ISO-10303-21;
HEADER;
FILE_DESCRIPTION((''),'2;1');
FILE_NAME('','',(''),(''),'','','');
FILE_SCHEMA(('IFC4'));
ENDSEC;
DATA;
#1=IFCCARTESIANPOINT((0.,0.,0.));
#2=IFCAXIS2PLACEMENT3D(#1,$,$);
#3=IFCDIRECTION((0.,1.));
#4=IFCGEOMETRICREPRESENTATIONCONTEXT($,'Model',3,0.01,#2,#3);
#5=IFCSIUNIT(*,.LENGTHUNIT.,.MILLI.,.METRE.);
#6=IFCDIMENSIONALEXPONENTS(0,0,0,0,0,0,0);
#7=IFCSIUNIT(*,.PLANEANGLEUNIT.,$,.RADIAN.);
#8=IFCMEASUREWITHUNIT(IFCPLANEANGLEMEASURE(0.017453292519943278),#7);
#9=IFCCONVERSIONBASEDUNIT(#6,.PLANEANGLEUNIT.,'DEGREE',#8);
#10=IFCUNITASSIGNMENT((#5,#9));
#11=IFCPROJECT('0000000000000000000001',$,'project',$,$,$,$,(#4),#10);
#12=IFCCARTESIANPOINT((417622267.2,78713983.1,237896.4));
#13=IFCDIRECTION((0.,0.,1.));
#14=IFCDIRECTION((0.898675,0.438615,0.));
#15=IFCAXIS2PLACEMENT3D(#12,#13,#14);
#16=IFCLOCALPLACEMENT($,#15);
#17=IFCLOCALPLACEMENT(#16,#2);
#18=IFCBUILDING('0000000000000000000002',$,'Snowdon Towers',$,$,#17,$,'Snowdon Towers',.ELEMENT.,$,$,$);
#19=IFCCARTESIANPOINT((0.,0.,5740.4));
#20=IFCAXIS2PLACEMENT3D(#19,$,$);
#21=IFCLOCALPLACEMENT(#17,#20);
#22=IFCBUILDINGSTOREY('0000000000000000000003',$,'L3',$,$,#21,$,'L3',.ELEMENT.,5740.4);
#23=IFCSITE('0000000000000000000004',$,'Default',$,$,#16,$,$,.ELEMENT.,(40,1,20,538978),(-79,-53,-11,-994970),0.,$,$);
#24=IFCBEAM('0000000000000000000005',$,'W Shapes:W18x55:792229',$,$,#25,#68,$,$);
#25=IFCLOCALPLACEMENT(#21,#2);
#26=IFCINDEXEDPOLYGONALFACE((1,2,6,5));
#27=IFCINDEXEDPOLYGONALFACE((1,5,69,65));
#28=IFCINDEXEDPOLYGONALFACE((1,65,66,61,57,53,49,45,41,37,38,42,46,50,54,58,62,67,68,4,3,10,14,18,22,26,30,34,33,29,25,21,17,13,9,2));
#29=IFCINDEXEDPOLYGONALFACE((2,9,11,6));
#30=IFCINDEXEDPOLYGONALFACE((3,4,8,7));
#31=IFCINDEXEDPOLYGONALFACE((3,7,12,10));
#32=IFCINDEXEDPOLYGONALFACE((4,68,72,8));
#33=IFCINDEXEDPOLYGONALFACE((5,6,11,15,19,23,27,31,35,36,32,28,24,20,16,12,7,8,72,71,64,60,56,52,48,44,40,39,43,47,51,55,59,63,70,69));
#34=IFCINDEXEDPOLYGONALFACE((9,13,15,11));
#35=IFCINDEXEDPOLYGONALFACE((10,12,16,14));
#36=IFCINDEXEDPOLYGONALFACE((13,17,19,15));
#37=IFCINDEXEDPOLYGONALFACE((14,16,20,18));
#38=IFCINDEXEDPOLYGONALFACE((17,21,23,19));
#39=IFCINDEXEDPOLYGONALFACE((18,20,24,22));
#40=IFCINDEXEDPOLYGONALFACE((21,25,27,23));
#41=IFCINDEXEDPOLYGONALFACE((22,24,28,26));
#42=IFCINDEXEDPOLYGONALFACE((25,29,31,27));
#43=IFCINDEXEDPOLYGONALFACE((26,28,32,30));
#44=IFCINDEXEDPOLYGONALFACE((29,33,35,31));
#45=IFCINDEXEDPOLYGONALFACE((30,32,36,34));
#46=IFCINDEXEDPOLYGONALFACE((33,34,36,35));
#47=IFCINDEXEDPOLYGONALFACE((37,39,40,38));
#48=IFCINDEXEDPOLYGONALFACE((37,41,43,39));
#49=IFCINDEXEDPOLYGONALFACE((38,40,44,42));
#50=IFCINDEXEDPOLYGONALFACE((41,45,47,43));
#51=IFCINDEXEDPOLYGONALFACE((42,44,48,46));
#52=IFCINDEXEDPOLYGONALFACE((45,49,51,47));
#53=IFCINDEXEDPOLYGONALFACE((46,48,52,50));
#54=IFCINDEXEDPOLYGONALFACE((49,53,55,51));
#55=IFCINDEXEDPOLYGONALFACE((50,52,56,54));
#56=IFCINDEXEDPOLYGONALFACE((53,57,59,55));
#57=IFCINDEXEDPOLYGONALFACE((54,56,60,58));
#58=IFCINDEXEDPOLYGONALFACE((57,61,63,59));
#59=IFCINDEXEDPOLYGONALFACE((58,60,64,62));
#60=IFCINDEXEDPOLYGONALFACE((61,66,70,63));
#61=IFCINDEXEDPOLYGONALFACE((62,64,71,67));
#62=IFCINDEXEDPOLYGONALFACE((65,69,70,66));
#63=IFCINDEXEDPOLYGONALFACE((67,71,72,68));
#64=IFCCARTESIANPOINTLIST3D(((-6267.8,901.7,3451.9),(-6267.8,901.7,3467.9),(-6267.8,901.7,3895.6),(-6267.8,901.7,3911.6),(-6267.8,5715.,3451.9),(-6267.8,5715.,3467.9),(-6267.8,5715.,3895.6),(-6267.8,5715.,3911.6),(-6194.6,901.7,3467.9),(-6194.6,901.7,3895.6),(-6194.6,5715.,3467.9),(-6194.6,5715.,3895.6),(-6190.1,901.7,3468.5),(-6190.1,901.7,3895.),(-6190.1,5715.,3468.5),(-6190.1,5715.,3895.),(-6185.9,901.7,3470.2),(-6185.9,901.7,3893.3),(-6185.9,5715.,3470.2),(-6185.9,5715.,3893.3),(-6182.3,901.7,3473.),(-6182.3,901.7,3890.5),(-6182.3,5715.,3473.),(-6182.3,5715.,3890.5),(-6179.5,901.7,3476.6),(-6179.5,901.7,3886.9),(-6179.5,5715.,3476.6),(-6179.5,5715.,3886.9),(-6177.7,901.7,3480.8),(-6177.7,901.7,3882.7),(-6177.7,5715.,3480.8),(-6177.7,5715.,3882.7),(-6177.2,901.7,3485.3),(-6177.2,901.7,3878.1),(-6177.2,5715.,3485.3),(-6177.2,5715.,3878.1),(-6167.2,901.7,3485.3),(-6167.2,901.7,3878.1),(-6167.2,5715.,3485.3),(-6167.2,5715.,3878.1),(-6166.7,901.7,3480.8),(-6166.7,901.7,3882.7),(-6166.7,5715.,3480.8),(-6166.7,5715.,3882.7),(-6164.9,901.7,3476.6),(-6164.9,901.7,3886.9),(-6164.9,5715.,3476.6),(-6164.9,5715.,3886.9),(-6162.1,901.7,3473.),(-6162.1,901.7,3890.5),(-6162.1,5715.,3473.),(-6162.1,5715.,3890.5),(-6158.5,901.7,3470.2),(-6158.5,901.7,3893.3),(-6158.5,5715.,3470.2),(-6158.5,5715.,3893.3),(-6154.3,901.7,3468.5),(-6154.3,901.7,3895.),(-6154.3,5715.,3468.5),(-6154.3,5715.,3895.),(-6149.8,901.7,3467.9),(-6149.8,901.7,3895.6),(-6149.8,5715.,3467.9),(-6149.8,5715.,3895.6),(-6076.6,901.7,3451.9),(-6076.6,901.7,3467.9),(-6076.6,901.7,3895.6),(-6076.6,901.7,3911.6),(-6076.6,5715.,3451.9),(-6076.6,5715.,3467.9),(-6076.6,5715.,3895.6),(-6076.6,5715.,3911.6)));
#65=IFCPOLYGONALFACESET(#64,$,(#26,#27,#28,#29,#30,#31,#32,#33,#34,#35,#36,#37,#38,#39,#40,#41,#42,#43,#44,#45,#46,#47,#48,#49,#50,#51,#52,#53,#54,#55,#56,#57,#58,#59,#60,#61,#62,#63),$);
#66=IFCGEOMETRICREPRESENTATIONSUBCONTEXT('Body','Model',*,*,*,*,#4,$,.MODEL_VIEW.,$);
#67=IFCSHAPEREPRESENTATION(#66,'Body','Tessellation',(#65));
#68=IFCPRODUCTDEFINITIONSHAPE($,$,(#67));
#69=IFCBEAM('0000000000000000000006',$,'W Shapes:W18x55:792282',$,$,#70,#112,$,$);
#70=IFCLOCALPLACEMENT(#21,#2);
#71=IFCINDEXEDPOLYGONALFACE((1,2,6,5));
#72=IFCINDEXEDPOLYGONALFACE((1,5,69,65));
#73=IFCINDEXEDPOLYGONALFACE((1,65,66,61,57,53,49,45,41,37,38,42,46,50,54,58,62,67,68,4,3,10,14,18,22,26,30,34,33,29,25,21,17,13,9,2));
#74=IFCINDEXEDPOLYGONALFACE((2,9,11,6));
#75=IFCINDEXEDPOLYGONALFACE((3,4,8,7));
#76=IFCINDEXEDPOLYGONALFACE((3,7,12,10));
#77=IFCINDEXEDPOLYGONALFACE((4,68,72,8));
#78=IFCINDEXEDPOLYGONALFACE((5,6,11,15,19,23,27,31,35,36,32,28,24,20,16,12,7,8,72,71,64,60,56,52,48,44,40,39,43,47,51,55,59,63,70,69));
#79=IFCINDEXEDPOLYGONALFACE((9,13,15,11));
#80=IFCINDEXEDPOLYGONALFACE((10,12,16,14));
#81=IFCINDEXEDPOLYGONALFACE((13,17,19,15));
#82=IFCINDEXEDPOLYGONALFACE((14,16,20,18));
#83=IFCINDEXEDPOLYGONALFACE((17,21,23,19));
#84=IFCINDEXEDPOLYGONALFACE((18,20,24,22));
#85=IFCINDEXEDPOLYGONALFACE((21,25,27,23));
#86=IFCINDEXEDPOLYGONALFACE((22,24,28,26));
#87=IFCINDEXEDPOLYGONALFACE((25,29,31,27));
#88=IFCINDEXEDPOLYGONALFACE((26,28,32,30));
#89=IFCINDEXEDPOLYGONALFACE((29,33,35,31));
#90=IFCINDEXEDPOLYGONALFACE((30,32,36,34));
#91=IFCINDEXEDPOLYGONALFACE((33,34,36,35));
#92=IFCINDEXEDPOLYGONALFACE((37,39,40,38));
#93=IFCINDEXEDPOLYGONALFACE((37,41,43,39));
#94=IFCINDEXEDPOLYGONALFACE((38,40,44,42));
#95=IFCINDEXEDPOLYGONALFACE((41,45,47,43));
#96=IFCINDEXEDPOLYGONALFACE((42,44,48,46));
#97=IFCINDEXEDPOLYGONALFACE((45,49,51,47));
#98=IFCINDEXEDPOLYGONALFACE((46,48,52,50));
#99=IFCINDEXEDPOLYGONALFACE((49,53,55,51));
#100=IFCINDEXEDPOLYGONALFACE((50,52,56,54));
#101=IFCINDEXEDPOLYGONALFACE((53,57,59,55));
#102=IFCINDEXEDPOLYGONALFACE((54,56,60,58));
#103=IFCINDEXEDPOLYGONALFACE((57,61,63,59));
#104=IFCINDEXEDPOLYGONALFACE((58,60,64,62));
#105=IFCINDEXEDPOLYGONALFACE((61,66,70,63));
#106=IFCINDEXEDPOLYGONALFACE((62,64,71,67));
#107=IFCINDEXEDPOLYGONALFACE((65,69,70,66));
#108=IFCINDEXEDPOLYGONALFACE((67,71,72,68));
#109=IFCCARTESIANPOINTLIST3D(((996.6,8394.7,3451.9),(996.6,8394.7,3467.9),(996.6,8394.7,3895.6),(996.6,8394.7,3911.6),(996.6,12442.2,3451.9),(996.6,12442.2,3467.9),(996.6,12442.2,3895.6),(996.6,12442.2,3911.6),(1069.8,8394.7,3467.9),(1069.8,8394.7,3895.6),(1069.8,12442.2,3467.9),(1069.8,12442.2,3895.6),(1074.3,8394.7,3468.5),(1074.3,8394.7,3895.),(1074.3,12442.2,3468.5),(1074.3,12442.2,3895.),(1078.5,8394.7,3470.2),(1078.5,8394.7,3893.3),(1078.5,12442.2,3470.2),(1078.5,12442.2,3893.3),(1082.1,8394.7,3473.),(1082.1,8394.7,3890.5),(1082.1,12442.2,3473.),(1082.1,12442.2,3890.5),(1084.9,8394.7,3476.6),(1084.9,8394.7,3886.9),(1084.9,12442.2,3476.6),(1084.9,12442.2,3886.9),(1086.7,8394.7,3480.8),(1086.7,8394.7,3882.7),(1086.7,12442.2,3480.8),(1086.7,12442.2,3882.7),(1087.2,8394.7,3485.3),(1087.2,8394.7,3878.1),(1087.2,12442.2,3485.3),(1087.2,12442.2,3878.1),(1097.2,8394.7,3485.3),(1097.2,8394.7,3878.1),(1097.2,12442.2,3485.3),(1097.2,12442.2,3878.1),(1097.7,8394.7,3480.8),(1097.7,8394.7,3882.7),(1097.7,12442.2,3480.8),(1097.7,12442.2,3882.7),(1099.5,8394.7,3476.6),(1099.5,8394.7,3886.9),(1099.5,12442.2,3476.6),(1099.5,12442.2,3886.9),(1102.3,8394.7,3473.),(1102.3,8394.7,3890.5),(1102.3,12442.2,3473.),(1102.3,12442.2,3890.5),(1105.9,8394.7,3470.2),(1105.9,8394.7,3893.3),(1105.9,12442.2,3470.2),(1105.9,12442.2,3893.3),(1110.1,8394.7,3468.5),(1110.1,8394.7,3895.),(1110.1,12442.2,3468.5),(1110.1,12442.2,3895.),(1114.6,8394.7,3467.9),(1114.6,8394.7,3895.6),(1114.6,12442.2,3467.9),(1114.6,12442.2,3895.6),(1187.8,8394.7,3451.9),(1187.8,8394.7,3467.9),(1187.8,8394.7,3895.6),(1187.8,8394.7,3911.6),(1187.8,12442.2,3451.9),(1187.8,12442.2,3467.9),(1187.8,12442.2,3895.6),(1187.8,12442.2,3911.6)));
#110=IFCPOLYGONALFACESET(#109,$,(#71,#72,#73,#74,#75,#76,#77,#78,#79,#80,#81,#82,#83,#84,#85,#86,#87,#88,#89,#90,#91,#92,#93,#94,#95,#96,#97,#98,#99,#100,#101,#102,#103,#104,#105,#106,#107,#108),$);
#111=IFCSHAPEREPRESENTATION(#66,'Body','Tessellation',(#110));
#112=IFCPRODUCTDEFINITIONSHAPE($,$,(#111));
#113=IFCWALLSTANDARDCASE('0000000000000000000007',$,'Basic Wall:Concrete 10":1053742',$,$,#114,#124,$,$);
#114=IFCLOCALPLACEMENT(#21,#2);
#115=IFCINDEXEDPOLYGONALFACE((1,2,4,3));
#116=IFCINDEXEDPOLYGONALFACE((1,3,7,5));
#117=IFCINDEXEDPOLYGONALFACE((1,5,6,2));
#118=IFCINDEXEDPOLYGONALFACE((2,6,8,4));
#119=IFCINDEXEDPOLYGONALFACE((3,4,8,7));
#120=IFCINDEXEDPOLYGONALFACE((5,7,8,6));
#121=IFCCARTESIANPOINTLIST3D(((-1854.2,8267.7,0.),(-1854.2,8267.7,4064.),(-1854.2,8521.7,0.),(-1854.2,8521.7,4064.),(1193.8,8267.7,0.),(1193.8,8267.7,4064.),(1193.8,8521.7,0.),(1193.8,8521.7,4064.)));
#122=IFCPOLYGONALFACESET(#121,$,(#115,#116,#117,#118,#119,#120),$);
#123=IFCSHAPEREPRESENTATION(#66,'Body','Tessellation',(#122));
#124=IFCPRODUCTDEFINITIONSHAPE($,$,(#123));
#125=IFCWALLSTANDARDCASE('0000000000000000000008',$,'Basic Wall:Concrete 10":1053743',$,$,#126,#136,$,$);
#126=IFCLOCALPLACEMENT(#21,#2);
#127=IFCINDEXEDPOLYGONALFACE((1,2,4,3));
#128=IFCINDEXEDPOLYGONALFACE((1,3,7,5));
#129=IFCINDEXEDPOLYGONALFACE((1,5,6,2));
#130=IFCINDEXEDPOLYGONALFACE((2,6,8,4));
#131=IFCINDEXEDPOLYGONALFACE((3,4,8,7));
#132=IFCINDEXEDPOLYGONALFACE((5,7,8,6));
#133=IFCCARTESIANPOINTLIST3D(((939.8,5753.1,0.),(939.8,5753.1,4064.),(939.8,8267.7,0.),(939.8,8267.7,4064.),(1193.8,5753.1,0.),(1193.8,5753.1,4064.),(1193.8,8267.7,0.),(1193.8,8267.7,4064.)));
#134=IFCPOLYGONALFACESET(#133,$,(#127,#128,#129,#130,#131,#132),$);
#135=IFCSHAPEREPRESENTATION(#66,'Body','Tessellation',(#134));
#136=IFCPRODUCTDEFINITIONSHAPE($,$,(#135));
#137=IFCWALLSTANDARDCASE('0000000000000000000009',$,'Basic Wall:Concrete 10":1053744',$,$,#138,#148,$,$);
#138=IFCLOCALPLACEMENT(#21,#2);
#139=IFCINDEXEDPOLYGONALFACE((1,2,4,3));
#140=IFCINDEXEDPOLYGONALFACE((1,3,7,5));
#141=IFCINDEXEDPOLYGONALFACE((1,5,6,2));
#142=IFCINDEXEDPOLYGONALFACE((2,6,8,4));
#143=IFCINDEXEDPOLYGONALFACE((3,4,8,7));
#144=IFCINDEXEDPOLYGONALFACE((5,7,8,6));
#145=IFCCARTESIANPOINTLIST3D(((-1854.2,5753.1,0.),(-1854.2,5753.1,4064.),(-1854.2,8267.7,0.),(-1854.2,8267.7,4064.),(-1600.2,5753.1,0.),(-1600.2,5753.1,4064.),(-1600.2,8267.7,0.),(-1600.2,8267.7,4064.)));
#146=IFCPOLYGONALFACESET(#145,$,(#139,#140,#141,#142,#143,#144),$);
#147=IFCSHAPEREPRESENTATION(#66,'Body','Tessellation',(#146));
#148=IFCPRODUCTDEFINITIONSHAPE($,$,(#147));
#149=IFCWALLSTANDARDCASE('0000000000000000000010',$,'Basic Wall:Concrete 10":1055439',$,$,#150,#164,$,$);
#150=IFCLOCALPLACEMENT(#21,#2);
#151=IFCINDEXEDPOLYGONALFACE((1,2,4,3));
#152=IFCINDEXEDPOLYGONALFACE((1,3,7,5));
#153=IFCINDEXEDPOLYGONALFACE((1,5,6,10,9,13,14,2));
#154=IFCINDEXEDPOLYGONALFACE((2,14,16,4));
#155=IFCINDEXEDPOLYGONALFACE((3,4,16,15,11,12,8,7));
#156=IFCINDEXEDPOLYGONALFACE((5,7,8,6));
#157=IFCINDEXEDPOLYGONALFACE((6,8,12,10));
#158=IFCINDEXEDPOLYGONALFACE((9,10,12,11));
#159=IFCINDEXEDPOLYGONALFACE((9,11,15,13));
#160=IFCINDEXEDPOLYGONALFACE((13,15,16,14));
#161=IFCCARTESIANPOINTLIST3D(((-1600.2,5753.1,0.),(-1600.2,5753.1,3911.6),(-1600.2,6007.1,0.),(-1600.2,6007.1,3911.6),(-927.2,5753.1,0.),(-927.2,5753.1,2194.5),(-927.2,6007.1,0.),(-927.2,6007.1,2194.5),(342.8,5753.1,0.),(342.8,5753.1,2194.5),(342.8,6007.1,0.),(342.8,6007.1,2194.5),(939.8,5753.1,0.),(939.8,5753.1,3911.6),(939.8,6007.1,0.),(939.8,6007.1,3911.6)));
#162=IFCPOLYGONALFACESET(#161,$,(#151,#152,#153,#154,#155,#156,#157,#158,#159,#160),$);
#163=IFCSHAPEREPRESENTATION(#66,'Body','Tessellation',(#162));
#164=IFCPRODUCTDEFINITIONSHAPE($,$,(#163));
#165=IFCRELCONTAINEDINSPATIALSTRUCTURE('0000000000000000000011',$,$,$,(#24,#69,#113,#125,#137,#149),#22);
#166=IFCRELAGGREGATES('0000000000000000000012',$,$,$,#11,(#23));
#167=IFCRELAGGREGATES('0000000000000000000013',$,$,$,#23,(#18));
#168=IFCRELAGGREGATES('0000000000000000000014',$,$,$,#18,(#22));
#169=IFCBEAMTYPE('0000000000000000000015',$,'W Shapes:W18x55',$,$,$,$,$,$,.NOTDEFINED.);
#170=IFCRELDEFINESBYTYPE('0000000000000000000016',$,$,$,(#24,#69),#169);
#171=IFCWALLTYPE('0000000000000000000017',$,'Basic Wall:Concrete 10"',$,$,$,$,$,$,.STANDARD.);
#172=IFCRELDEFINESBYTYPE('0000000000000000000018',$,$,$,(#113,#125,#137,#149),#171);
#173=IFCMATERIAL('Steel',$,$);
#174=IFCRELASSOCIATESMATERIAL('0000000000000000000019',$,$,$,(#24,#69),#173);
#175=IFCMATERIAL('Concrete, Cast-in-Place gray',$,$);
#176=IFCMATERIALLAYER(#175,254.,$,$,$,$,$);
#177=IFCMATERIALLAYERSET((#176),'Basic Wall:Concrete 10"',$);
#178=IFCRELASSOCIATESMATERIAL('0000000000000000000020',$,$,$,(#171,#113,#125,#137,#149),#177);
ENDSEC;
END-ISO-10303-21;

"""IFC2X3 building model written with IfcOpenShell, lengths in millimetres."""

from ifc_helpers import new_model, entity, si_unit, converted_unit, direction, frame, frame_2d, origin, place, context, subcontext, project, spatial, rectangle, i_section, extrude, material, layer, layer_set, layer_usage, type_object, element, save


model = new_model("IFC2X3")

# Units and contexts
model_context = context("Model", 3, precision=0.01, world=origin(), true_north=direction((0.0, 1.0)))
body_context = subcontext(model_context, "Body", "Model", "MODEL_VIEW")
ifc_project = project(units=[si_unit("LENGTHUNIT", "METRE", prefix="MILLI"), converted_unit("PLANEANGLEUNIT", "DEGREE", entity("IfcPlaneAngleMeasure", 0.017453292519943278), si_unit("PLANEANGLEUNIT", "RADIAN"), dimensions=[0, 0, 0, 0, 0, 0, 0])], contexts=[model_context])

# Site, building, storey
site_placement = place(None, frame((417622267.2, 78713983.1, 237896.4), z_axis=(0.0, 0.0, 1.0), x_axis=(0.898675, 0.438615, 0.0)))
site = spatial("IfcSite", under=ifc_project, at=site_placement, Name="Default", CompositionType="ELEMENT", RefLatitude=(40, 1, 20, 538978), RefLongitude=(-79, -53, -11, -994970), RefElevation=0.0)
building_placement = place(site_placement, origin())
building = spatial("IfcBuilding", under=site, at=building_placement, Name="Snowdon Towers", LongName="Snowdon Towers", CompositionType="ELEMENT")
storey_placement = place(building_placement, frame((0.0, 0.0, 5740.4)))
storey = spatial("IfcBuildingStorey", under=building, at=storey_placement, Name="L3", LongName="L3", CompositionType="ELEMENT", Elevation=5740.4)

# Shared definitions
ifc_material_1 = material(Name="Steel")

# Beams
beam_type = type_object("IfcBeamType", Name="W Shapes:W18x55", PredefinedType="NOTDEFINED")
beam_1_placement = place(storey_placement, frame((-6172.2, 5854.7, 3911.6), z_axis=(0.0, 0.0, 1.0), x_axis=(0.0, -1.0, 0.0)))
element("IfcBeam", 1, at=beam_1_placement, inside=storey, type_object=beam_type, material=ifc_material_1, Name="W Shapes:W18x55:792229", context=body_context, shape_type="SweptSolid", body=[
    extrude(i_section(OverallWidth=191.3, OverallDepth=459.7, WebThickness=9.9, FlangeThickness=16.0, FilletRadius=17.5, at=frame_2d((0.0, 0.0), x_axis=(0.0, 1.0))), frame((139.7, 0.0, -229.9), z_axis=(1.0, 0.0, 0.0), x_axis=(0.0, 0.0, -1.0)), (0.0, 0.0, 1.0), 4813.3),
])
beam_2_placement = place(storey_placement, frame((1092.2, 12636.5, 3911.6), z_axis=(0.0, 0.0, 1.0), x_axis=(0.0, -1.0, 0.0)))
element("IfcBeam", 2, at=beam_2_placement, inside=storey, type_object=beam_type, material=ifc_material_1, Name="W Shapes:W18x55:792282", context=body_context, shape_type="SweptSolid", body=[
    extrude(i_section(OverallWidth=191.3, OverallDepth=459.7, WebThickness=9.9, FlangeThickness=16.0, FilletRadius=17.5, at=frame_2d((0.0, 0.0), x_axis=(0.0, 1.0))), frame((194.3, 0.0, -229.9), z_axis=(1.0, 0.0, 0.0), x_axis=(0.0, 0.0, -1.0)), (0.0, 0.0, 1.0), 4047.5),
])

# Shared definitions
ifc_material_2 = material(Name="Concrete, Cast-in-Place gray")

# Walls
ifc_layer_1 = layer(ifc_material_2, 254.0)
ifc_layer_set_1 = layer_set([ifc_layer_1], Name="Basic Wall:Concrete 10\"")
ifc_layer_usage_1 = layer_usage(ifc_layer_set_1, "AXIS2", "POSITIVE", -127.0)
wall_type = type_object("IfcWallType", Name="Basic Wall:Concrete 10\"", PredefinedType="STANDARD", material=ifc_layer_set_1)
wall_1_placement = place(storey_placement, frame((-1854.2, 8394.7, 0.0)))
element("IfcWallStandardCase", 3, at=wall_1_placement, inside=storey, type_object=wall_type, material=ifc_layer_usage_1, Name="Basic Wall:Concrete 10\":1053742", context=body_context, shape_type="SweptSolid", body=[
    extrude(rectangle(XDim=3048.0, YDim=254.0, at=frame_2d((1524.0, 0.0), x_axis=(-1.0, 0.0))), origin(), (0.0, 0.0, 1.0), 4064.0),
])
ifc_layer_usage_2 = layer_usage(ifc_layer_set_1, "AXIS2", "POSITIVE", -127.0)
wall_2_placement = place(storey_placement, frame((1066.8, 8267.7, 0.0), z_axis=(0.0, 0.0, 1.0), x_axis=(0.0, -1.0, 0.0)))
element("IfcWallStandardCase", 4, at=wall_2_placement, inside=storey, type_object=wall_type, material=ifc_layer_usage_2, Name="Basic Wall:Concrete 10\":1053743", context=body_context, shape_type="SweptSolid", body=[
    extrude(rectangle(XDim=2514.6, YDim=254.0, at=frame_2d((1257.3, 0.0), x_axis=(-1.0, 0.0))), origin(), (0.0, 0.0, 1.0), 4064.0),
])
ifc_layer_usage_3 = layer_usage(ifc_layer_set_1, "AXIS2", "POSITIVE", -127.0)
wall_3_placement = place(storey_placement, frame((-1727.2, 5753.1, 0.0), z_axis=(0.0, 0.0, 1.0), x_axis=(0.0, 1.0, 0.0)))
element("IfcWallStandardCase", 5, at=wall_3_placement, inside=storey, type_object=wall_type, material=ifc_layer_usage_3, Name="Basic Wall:Concrete 10\":1053744", context=body_context, shape_type="SweptSolid", body=[
    extrude(rectangle(XDim=2514.6, YDim=254.0, at=frame_2d((1257.3, 0.0), x_axis=(-1.0, 0.0))), origin(), (0.0, 0.0, 1.0), 4064.0),
])

# Wall, opening
ifc_layer_usage_4 = layer_usage(ifc_layer_set_1, "AXIS2", "POSITIVE", -127.0)
wall_4_placement = place(storey_placement, frame((939.8, 5880.1, 0.0), z_axis=(0.0, 0.0, 1.0), x_axis=(-1.0, 0.0, 0.0)))
wall_4 = element("IfcWallStandardCase", 6, at=wall_4_placement, inside=storey, type_object=wall_type, material=ifc_layer_usage_4, Name="Basic Wall:Concrete 10\":1055439", context=body_context, shape_type="SweptSolid", body=[
    extrude(rectangle(XDim=2540.0, YDim=254.0, at=frame_2d((1270.0, 0.0), x_axis=(-1.0, 0.0))), origin(), (0.0, 0.0, 1.0), 3911.6),
])
opening_1_placement = place(wall_4_placement, origin())
element("IfcOpeningElement", 7, at=opening_1_placement, cuts=wall_4, ObjectType="Opening", context=body_context, shape_type="SweptSolid", body=[
    extrude(rectangle(XDim=2194.5, YDim=1270.0, at=frame_2d((0.0, 0.0), x_axis=(0.0, -1.0))), frame((1232.0, 127.0, 1097.2), z_axis=(0.0, 1.0, 0.0), x_axis=(1.0, 0.0, 0.0)), (0.0, 0.0, -1.0), 254.0),
])

save(model, "model.ifc")
